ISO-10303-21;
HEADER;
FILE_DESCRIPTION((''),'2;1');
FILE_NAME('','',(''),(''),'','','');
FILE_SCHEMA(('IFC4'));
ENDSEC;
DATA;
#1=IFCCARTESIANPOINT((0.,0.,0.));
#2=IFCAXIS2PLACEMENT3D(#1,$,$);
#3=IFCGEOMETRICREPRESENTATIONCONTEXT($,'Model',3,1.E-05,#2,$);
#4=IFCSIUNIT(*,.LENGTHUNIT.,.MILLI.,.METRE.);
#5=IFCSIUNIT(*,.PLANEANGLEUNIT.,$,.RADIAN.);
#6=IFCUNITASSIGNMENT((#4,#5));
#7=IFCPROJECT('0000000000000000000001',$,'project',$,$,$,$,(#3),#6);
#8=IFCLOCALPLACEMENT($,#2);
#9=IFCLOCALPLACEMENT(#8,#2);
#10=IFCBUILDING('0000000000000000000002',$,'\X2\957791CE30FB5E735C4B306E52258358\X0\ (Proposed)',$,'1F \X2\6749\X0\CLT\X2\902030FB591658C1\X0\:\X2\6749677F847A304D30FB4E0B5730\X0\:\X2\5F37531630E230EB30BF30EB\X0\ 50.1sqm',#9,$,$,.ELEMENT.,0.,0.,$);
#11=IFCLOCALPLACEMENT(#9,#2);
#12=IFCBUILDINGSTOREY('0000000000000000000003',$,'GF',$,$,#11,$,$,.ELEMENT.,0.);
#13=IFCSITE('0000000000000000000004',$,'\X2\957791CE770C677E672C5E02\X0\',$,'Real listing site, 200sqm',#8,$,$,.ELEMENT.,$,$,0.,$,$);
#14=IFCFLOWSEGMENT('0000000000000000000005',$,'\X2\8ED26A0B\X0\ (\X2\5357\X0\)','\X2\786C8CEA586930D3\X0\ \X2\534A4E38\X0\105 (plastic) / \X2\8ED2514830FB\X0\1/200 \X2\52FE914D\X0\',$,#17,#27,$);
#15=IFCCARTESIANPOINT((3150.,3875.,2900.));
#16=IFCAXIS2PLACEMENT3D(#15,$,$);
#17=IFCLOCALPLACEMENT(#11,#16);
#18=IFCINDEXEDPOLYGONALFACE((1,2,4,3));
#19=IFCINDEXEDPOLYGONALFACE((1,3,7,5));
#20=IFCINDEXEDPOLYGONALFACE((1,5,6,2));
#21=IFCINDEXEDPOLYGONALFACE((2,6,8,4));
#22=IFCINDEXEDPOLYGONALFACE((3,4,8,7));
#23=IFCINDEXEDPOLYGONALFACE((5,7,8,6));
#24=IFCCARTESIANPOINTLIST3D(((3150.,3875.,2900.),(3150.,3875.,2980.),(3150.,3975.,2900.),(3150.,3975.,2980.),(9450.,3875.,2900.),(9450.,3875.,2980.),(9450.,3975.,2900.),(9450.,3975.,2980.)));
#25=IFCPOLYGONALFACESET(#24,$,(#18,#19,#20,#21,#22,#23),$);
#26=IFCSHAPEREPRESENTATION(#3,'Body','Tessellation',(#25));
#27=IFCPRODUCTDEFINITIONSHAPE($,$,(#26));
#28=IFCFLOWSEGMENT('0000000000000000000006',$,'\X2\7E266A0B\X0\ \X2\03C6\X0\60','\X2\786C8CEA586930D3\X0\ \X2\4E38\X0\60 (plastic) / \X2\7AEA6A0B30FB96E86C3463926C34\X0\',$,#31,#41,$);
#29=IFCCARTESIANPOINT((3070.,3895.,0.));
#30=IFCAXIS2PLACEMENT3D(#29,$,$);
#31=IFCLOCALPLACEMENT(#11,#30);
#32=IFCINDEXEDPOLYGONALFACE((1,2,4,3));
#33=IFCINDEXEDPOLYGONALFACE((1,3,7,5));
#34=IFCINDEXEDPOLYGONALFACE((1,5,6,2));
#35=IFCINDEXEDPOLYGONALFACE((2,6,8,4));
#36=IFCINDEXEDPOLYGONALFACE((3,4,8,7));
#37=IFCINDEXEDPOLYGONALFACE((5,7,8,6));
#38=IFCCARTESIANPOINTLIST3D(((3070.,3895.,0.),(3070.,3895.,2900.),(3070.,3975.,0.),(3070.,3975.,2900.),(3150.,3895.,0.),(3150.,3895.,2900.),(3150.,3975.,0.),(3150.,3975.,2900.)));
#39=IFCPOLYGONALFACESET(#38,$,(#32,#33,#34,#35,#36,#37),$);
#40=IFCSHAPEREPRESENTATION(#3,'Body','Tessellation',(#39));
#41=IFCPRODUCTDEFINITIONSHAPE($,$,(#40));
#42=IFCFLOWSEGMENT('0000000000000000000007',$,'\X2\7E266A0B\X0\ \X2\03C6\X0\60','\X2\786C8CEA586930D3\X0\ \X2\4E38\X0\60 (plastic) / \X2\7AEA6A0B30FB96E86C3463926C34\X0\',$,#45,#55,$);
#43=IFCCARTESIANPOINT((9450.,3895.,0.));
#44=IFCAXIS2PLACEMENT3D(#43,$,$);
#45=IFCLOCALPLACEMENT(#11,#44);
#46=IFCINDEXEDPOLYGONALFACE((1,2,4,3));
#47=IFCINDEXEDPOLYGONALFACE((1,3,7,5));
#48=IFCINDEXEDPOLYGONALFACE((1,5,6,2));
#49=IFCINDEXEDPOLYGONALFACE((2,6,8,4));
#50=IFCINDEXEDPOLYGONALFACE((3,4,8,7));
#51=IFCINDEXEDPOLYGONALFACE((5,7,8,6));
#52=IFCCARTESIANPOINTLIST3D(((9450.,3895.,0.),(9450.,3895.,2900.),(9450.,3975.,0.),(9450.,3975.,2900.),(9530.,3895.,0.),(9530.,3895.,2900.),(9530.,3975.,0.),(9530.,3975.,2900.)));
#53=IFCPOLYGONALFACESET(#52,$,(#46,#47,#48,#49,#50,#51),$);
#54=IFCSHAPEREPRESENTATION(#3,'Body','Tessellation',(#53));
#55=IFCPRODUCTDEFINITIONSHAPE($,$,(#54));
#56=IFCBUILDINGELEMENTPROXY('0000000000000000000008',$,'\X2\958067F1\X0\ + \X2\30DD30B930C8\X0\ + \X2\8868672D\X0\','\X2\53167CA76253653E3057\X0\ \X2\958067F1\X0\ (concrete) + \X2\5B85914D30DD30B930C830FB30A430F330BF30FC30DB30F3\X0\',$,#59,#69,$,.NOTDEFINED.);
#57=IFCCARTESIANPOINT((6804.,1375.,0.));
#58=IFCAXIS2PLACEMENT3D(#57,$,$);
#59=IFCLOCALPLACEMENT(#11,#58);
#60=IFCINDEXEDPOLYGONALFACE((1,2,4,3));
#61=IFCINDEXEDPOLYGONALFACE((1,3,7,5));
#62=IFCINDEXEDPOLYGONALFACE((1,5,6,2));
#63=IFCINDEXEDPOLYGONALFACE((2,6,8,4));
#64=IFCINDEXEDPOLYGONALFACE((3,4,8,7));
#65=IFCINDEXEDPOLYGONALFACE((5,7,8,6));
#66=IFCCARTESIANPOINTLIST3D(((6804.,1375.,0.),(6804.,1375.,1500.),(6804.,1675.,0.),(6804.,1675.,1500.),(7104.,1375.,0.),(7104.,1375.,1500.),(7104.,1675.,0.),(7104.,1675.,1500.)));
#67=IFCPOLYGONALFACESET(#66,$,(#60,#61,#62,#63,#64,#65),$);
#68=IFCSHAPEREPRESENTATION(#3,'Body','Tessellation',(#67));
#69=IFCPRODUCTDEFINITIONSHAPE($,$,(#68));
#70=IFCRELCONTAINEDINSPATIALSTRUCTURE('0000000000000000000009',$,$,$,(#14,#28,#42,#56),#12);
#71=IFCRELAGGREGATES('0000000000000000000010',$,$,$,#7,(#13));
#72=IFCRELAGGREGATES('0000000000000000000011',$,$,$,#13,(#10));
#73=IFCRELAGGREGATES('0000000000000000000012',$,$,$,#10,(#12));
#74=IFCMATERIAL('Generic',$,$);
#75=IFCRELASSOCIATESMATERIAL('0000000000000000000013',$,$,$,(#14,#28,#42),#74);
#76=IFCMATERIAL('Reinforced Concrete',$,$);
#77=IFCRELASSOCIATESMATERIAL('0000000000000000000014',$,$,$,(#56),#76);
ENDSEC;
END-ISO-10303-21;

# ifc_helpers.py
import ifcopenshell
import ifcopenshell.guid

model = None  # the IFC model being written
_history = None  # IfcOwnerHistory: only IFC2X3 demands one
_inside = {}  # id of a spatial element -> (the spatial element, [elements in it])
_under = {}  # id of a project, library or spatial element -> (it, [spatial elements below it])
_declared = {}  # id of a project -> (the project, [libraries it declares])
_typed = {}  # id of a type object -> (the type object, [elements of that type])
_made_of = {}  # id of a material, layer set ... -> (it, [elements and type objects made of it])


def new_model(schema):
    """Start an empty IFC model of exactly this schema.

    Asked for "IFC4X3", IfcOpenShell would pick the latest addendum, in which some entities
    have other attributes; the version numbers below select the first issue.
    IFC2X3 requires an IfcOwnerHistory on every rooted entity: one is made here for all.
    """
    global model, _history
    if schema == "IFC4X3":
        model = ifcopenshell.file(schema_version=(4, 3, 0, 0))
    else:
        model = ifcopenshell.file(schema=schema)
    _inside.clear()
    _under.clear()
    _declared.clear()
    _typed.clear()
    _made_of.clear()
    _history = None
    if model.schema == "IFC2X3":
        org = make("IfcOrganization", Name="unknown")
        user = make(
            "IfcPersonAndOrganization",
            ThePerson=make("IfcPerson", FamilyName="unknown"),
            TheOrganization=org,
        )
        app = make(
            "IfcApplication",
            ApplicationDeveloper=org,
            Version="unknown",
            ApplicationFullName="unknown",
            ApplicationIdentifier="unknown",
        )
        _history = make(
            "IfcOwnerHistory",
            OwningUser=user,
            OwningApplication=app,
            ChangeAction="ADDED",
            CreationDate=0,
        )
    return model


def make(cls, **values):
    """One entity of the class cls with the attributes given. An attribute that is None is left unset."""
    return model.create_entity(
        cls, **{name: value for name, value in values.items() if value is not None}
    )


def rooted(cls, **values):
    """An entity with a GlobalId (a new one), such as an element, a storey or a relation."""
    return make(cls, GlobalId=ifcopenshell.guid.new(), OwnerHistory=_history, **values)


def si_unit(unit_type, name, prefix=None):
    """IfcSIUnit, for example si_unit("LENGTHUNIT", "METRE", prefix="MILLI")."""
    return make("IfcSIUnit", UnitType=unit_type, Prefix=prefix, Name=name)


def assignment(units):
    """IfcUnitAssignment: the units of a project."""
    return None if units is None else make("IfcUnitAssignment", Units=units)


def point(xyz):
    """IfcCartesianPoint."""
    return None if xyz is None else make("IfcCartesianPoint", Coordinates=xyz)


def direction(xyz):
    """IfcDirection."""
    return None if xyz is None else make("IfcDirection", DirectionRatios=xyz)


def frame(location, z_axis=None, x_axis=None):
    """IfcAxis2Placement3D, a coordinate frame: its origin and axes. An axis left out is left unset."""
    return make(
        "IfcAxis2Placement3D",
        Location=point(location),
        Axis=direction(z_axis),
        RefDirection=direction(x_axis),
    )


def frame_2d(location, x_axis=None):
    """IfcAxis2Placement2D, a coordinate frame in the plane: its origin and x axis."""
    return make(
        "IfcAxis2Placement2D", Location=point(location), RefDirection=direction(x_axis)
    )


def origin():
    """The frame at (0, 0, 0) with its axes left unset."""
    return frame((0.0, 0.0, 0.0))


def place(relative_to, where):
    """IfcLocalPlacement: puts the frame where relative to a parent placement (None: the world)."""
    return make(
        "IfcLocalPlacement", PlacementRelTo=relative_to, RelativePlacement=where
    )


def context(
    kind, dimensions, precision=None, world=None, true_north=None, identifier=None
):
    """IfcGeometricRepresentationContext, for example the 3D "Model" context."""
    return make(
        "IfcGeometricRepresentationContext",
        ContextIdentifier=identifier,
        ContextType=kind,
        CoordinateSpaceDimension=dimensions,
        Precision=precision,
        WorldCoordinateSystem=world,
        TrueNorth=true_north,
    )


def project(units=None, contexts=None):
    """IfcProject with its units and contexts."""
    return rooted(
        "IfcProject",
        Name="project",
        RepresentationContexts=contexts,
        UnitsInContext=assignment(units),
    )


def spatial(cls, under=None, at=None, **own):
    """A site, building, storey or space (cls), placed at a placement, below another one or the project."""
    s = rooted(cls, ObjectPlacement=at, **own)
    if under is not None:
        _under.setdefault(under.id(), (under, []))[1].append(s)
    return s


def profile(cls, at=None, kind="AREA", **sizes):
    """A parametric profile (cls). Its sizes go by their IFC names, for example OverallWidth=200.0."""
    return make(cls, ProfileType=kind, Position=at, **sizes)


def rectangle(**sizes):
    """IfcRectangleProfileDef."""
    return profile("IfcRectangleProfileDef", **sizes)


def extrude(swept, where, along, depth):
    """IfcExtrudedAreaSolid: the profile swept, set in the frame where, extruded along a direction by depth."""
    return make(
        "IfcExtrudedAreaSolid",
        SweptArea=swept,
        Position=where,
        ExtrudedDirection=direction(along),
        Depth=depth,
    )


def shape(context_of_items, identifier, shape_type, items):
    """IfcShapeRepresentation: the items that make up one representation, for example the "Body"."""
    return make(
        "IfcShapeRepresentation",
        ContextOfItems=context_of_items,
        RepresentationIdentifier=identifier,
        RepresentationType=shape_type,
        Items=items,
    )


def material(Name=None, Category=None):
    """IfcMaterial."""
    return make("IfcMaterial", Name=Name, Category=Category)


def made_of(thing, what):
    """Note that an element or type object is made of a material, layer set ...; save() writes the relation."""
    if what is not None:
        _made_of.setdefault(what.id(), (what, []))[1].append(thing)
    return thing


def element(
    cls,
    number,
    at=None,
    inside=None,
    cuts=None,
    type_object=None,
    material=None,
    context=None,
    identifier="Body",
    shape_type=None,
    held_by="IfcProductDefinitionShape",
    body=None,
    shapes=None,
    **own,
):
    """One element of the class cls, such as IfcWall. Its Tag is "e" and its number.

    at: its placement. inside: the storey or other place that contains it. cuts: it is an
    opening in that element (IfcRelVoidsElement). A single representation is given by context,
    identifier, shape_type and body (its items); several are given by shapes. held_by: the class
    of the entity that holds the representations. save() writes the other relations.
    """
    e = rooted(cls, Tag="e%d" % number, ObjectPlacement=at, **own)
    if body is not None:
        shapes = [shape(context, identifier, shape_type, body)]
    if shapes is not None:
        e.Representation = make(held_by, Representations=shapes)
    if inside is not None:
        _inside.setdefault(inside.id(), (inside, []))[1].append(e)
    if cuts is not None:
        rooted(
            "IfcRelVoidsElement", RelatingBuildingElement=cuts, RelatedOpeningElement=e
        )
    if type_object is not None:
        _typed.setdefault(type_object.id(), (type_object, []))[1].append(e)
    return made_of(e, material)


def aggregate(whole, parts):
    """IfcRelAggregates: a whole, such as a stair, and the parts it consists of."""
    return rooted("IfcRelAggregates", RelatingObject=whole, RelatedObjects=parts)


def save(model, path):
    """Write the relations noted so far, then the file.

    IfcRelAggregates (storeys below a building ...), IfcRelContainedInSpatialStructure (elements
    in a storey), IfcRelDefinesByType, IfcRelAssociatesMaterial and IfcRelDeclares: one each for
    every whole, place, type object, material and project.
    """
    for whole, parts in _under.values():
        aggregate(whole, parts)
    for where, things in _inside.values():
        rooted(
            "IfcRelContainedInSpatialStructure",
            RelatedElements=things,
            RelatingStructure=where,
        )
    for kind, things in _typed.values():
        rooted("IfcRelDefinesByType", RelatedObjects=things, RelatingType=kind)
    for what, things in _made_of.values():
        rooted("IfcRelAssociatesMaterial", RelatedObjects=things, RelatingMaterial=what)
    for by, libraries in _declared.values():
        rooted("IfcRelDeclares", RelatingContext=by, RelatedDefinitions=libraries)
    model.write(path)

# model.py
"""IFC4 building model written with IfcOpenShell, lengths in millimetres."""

from ifc_helpers import new_model, si_unit, frame, frame_2d, origin, place, context, project, spatial, rectangle, extrude, material, element, save


model = new_model("IFC4")

# Units and contexts
model_context = context("Model", 3, precision=1e-05, world=origin())
ifc_project = project(units=[si_unit("LENGTHUNIT", "METRE", prefix="MILLI"), si_unit("PLANEANGLEUNIT", "RADIAN")], contexts=[model_context])

# Site, building, storey
site_placement = place(None, origin())
site = spatial("IfcSite", under=ifc_project, at=site_placement, Name="長野県松本市", ObjectType="Real listing site, 200sqm", CompositionType="ELEMENT", RefElevation=0.0)
building_placement = place(site_placement, origin())
building = spatial("IfcBuilding", under=site, at=building_placement, Name="長野・平屋の別荘 (Proposed)", ObjectType="1F 杉CLT造・外壁:杉板葺き・下地:強化モルタル 50.1sqm", CompositionType="ELEMENT", ElevationOfRefHeight=0.0, ElevationOfTerrain=0.0)
storey_placement = place(building_placement, origin())
storey = spatial("IfcBuildingStorey", under=building, at=storey_placement, Name="GF", CompositionType="ELEMENT", Elevation=0.0)

# Shared definitions
ifc_material_1 = material(Name="Reinforced Concrete")

# Flow segments
ifc_material_2 = material(Name="Generic")
flow_segment_1_placement = place(storey_placement, frame((3150.0, 3875.0, 2900.0)))
element("IfcFlowSegment", 1, at=flow_segment_1_placement, inside=storey, material=ifc_material_2, Name="軒樋 (南)", Description="硬質塩ビ 半丸105 (plastic) / 軒先・1/200 勾配", context=model_context, shape_type="SweptSolid", body=[
    extrude(rectangle(XDim=6300.0, YDim=100.0, at=frame_2d((3150.0, 50.0))), frame((3150.0, 3875.0, 2900.0)), (0.0, 0.0, 1.0), 80.0),
])
flow_segment_2_placement = place(storey_placement, frame((3070.0, 3895.0, 0.0)))
element("IfcFlowSegment", 2, at=flow_segment_2_placement, inside=storey, material=ifc_material_2, Name="縦樋 φ60", Description="硬質塩ビ 丸60 (plastic) / 竪樋・雨水排水", context=model_context, shape_type="SweptSolid", body=[
    extrude(rectangle(XDim=80.0, YDim=80.0, at=frame_2d((40.0, 40.0))), frame((3070.0, 3895.0, 0.0)), (0.0, 0.0, 1.0), 2900.0),
])
flow_segment_3_placement = place(storey_placement, frame((9450.0, 3895.0, 0.0)))
element("IfcFlowSegment", 3, at=flow_segment_3_placement, inside=storey, material=ifc_material_2, Name="縦樋 φ60", Description="硬質塩ビ 丸60 (plastic) / 竪樋・雨水排水", context=model_context, shape_type="SweptSolid", body=[
    extrude(rectangle(XDim=80.0, YDim=80.0, at=frame_2d((40.0, 40.0))), frame((9450.0, 3895.0, 0.0)), (0.0, 0.0, 1.0), 2900.0),
])

# Building element proxy
proxy_placement = place(storey_placement, frame((6804.0, 1375.0, 0.0)))
element("IfcBuildingElementProxy", 4, at=proxy_placement, inside=storey, material=ifc_material_1, Name="門柱 + ポスト + 表札", Description="化粧打放し 門柱 (concrete) + 宅配ポスト・インターホン", PredefinedType="NOTDEFINED", context=model_context, shape_type="SweptSolid", body=[
    extrude(rectangle(XDim=300.0, YDim=300.0, at=frame_2d((150.0, 150.0))), frame((6804.0, 1375.0, 0.0)), (0.0, 0.0, 1.0), 1500.0),
])

save(model, "model.ifc")
